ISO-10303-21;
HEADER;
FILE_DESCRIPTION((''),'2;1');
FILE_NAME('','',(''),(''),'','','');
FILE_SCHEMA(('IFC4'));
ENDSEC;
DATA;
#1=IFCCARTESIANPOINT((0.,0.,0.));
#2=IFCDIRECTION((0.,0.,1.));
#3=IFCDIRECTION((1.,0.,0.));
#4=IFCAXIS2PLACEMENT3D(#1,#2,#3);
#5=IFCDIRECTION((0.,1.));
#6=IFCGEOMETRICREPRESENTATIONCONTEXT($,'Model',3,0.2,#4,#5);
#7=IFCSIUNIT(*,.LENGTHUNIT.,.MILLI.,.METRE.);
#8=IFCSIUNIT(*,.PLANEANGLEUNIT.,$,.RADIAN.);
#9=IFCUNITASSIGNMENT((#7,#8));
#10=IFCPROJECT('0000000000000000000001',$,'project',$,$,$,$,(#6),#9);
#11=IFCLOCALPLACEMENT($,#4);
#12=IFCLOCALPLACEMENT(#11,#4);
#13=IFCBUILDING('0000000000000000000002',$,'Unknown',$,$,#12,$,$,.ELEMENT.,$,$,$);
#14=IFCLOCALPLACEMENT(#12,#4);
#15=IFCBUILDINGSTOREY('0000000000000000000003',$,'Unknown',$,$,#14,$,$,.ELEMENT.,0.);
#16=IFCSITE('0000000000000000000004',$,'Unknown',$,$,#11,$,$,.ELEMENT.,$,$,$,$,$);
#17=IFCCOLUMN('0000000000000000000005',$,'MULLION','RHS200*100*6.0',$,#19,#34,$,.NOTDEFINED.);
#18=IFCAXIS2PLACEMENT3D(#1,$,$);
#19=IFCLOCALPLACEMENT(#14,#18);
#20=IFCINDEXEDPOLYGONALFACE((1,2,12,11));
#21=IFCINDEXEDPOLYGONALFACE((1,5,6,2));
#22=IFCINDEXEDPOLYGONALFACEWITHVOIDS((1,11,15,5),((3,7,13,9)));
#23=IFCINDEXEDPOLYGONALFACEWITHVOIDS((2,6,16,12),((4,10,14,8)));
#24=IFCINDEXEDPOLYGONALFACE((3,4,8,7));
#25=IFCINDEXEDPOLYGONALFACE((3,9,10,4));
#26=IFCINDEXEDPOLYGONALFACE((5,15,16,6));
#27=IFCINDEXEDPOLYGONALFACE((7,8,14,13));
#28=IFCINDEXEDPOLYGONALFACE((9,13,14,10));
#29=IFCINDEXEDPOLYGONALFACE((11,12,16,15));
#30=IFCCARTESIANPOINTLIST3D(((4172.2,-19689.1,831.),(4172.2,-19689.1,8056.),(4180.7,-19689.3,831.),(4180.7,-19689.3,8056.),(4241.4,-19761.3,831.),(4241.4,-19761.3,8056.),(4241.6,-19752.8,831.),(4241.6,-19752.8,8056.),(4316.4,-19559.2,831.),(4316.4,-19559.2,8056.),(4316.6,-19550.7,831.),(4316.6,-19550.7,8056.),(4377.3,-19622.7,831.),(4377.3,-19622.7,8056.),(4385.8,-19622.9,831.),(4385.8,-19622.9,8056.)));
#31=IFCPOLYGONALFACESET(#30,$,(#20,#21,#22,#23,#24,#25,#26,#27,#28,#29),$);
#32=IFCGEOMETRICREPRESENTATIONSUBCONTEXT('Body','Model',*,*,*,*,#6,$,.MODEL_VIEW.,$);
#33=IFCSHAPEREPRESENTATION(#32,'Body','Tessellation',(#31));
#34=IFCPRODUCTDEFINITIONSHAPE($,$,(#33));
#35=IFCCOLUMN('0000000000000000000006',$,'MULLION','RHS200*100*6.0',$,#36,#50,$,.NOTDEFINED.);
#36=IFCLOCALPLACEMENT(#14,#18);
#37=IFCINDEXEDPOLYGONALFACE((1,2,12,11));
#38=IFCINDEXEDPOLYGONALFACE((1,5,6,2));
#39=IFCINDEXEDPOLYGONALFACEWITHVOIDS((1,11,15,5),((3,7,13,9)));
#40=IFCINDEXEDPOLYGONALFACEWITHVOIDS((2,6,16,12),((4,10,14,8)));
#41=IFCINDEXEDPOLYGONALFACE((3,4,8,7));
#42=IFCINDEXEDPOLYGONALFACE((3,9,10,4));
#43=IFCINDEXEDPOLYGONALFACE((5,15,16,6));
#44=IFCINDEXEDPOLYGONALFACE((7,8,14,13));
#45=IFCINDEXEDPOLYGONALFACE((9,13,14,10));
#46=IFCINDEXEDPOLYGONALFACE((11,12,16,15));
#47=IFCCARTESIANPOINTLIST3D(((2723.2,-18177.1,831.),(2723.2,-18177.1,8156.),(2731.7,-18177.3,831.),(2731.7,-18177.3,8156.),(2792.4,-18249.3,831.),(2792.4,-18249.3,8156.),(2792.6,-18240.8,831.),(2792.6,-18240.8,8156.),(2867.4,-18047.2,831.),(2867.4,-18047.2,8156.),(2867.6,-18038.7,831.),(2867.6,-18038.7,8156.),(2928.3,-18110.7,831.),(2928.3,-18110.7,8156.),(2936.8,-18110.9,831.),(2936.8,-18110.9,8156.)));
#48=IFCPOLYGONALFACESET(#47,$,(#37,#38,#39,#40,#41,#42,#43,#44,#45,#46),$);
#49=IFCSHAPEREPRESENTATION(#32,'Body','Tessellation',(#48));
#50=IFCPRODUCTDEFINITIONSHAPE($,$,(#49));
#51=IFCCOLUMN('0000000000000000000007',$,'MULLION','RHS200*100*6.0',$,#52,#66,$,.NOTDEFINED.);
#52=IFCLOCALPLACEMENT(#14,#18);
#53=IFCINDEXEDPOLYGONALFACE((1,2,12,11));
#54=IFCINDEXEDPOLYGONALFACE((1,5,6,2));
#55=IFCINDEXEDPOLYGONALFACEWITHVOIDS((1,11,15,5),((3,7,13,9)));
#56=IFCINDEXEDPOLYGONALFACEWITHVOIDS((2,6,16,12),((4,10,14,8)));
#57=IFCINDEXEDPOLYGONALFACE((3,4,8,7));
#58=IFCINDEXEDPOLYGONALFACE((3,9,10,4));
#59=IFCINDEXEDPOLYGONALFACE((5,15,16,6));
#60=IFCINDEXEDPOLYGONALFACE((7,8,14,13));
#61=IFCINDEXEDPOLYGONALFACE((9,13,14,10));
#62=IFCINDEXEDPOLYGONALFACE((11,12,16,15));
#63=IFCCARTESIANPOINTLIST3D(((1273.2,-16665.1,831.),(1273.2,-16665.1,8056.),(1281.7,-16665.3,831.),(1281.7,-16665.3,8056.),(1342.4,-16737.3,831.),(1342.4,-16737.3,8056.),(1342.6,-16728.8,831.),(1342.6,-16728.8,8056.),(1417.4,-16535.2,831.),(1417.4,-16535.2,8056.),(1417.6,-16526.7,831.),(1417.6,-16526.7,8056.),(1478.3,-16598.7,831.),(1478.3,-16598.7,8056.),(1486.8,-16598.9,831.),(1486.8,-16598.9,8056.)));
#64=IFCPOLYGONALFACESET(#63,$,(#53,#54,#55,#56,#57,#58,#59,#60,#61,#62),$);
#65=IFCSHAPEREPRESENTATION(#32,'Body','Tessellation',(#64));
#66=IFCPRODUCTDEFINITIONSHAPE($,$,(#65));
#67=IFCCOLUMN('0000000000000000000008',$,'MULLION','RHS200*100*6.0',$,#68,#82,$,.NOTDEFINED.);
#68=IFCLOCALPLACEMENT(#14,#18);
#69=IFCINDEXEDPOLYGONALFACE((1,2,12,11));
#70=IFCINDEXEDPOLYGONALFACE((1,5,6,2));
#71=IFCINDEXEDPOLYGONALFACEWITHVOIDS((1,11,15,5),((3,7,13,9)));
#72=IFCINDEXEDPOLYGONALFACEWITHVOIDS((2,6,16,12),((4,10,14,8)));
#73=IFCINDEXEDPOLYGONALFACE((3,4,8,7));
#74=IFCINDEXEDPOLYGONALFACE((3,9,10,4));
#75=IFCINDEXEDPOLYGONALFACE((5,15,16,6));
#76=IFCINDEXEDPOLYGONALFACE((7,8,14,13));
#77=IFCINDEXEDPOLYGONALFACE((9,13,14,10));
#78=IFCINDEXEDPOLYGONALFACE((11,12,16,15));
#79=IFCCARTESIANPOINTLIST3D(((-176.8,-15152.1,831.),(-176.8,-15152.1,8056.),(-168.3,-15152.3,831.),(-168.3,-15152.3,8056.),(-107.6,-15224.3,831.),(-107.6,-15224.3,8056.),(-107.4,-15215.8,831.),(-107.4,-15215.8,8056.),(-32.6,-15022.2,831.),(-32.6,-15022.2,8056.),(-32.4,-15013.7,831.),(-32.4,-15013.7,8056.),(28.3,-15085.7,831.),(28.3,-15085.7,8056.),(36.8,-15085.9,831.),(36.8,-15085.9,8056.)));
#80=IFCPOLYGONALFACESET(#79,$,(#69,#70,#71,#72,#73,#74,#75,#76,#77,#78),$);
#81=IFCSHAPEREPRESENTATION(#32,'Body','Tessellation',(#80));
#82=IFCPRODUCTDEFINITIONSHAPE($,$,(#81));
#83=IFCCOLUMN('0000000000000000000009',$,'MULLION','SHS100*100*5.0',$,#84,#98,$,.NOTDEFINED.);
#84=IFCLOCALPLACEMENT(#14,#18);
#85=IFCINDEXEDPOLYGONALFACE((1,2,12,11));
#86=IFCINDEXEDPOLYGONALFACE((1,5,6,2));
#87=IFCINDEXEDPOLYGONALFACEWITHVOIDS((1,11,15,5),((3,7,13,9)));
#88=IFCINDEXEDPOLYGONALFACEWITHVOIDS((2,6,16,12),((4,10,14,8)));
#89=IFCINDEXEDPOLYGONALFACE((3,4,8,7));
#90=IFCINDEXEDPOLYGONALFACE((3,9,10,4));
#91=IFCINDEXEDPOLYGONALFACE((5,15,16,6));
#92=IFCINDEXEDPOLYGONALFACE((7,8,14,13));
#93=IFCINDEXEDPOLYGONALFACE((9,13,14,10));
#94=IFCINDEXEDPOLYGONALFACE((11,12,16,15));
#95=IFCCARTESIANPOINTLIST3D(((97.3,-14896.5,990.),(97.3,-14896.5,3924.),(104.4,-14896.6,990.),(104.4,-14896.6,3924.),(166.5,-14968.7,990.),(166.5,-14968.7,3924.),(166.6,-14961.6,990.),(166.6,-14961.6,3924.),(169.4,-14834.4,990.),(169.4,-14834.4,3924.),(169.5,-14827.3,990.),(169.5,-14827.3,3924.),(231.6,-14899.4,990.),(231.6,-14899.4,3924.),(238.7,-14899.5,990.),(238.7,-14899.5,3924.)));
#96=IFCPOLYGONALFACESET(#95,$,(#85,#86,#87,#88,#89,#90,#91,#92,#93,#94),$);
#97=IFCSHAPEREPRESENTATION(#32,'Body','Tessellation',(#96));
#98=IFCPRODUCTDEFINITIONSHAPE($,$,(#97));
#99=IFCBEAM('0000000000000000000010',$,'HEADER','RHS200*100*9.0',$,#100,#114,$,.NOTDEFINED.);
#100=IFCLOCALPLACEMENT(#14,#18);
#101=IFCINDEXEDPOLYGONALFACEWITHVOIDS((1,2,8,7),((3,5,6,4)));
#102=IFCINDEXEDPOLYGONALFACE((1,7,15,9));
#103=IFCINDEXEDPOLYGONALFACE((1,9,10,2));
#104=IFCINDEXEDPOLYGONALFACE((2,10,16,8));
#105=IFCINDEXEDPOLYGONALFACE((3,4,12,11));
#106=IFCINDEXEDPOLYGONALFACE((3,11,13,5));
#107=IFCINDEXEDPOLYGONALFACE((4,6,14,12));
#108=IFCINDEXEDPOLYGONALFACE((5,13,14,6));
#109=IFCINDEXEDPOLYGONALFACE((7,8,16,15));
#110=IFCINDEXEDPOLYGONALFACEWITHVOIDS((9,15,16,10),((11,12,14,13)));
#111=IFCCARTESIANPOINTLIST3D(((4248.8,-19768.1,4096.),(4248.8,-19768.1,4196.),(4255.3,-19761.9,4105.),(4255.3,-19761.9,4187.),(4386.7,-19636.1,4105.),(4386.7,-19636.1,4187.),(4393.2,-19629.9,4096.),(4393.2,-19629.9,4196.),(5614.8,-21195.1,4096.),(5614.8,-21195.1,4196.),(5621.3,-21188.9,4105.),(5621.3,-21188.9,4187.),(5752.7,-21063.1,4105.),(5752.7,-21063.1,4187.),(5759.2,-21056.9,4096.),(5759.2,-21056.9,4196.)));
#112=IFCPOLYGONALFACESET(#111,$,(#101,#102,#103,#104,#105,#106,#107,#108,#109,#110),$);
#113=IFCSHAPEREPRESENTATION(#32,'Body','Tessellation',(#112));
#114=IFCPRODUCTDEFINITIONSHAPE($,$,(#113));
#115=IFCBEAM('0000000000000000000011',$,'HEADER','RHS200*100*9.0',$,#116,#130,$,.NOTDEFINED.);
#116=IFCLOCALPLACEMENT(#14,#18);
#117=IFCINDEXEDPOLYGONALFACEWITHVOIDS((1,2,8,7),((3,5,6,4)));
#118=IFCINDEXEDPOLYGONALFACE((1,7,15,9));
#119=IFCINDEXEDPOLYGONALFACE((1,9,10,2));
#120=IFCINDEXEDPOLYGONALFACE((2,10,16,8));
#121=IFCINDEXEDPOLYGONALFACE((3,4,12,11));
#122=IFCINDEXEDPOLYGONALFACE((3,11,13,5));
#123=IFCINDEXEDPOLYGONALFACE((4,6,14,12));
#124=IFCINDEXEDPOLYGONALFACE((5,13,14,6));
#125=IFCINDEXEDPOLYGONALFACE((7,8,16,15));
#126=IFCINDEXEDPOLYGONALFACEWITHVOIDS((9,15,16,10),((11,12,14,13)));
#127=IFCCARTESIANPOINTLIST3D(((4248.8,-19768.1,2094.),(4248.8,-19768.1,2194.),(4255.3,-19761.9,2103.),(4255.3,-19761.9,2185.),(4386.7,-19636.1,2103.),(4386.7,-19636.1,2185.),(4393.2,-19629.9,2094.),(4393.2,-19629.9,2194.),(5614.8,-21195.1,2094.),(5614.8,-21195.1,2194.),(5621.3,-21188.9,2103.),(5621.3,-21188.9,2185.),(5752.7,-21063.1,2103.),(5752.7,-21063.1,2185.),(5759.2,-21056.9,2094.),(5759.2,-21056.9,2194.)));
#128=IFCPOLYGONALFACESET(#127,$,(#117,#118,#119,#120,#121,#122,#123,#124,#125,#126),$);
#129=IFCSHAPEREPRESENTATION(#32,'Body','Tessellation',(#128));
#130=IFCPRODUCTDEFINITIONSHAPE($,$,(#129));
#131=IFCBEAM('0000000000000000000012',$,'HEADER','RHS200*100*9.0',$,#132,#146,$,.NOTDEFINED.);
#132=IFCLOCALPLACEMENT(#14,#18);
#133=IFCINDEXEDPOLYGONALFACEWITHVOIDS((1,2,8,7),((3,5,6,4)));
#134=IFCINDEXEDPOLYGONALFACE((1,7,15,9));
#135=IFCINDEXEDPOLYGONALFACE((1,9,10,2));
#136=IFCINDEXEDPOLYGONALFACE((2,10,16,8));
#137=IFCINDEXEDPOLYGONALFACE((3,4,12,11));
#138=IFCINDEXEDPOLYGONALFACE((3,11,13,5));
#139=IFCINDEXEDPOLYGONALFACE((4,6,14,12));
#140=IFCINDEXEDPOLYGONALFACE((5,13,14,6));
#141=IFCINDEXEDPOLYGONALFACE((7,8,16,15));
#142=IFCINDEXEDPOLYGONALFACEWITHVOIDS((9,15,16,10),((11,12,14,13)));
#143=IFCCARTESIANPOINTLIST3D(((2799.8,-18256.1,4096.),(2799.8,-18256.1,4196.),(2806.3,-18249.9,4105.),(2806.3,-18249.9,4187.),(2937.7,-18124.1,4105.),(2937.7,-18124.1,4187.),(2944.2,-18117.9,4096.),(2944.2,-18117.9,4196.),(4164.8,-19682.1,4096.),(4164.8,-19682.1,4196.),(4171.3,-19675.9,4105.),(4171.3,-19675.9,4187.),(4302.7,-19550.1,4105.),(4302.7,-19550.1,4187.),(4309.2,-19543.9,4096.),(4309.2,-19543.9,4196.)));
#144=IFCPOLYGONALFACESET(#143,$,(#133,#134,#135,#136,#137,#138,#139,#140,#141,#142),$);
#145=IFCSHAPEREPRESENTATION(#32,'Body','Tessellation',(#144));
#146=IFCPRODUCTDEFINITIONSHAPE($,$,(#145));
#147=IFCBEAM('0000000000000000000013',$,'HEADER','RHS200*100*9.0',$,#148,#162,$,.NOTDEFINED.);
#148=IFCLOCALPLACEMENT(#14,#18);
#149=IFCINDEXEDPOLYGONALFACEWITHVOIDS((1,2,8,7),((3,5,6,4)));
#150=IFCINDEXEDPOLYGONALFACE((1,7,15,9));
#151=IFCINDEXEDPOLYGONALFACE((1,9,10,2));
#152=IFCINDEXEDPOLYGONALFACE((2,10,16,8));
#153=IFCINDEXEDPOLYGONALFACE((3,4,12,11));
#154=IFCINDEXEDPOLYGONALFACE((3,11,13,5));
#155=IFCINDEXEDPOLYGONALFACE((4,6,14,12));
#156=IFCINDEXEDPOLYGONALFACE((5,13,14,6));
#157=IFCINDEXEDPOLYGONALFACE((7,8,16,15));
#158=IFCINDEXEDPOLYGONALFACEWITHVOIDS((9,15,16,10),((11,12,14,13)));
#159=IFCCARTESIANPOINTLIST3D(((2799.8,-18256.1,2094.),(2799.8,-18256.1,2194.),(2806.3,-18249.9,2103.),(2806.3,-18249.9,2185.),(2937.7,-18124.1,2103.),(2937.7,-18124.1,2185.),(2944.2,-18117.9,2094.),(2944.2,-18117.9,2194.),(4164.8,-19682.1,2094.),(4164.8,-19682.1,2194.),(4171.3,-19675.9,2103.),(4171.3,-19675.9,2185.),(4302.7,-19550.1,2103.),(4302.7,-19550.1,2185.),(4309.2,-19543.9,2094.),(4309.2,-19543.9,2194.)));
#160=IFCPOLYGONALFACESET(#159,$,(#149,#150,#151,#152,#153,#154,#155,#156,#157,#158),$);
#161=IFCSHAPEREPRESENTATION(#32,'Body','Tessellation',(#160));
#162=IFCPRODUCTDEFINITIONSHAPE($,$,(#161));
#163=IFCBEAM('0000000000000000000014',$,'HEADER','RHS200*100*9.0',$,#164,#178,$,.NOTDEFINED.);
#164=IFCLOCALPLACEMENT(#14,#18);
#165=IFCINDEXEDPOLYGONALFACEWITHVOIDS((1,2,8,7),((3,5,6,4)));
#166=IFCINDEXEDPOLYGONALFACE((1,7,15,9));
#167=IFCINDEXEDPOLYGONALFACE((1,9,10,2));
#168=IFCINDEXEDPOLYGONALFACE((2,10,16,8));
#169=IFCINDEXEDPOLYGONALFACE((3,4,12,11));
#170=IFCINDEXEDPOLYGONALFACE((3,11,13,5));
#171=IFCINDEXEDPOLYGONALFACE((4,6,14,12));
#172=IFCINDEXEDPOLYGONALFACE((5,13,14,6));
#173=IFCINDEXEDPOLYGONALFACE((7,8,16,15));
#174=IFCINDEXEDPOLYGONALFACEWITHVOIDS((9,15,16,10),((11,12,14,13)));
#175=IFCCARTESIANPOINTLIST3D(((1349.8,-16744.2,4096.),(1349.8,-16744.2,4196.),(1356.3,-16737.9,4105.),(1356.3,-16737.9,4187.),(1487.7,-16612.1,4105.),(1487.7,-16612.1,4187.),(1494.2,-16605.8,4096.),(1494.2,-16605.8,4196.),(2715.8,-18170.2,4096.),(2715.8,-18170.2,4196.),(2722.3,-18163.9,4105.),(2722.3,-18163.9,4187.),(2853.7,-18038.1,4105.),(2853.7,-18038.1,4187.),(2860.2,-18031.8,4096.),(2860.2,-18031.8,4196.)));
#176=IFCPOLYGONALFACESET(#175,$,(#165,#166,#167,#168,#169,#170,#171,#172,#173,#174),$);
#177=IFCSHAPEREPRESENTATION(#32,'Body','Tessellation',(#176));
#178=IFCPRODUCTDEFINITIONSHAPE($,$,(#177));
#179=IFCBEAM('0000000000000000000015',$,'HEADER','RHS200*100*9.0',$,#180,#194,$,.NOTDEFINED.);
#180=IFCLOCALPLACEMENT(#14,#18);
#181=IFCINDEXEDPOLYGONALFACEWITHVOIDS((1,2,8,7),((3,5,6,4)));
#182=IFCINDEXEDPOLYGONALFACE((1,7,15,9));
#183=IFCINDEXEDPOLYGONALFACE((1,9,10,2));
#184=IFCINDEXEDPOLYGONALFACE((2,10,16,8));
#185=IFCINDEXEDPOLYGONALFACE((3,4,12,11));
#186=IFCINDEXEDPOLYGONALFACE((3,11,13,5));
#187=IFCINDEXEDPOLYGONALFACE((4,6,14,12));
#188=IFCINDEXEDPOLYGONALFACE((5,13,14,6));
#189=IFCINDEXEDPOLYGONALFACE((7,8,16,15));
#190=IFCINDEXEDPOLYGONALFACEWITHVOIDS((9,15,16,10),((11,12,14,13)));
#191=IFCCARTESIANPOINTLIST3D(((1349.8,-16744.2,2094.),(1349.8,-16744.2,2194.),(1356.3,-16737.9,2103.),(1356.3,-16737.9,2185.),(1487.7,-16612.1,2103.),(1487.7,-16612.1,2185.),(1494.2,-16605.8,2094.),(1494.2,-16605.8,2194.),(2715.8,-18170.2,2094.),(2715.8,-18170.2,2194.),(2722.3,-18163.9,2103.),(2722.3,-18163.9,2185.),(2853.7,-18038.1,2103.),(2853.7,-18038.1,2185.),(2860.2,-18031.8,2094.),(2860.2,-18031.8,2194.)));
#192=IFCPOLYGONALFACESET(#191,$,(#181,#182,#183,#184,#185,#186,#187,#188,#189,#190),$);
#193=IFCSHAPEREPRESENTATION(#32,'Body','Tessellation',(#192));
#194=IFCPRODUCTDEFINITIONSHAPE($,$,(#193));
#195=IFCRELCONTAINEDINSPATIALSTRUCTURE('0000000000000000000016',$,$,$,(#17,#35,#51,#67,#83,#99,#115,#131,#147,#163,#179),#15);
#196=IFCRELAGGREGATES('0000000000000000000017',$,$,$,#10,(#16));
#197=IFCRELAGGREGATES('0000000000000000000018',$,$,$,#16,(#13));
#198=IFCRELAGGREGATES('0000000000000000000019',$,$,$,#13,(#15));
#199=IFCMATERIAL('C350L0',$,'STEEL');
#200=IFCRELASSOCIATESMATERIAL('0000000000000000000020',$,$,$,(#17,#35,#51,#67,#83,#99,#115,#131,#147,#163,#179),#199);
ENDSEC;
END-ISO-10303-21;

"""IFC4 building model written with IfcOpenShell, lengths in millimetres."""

from ifc_helpers import new_model, si_unit, direction, frame, origin_with_axes, place, context, subcontext, project, spatial, line, indexed_curve, outline, extrude, material, element, save


model = new_model("IFC4")

# Units and contexts
model_context = context("Model", 3, precision=0.2, world=origin_with_axes(), true_north=direction((0.0, 1.0)))
body_context = subcontext(model_context, "Body", "Model", "MODEL_VIEW")
ifc_project = project(units=[si_unit("LENGTHUNIT", "METRE", prefix="MILLI"), si_unit("PLANEANGLEUNIT", "RADIAN")], contexts=[model_context])

# Site, building, storey
site_placement = place(None, origin_with_axes())
site = spatial("IfcSite", under=ifc_project, at=site_placement, Name="Unknown", CompositionType="ELEMENT")
building_placement = place(site_placement, origin_with_axes())
building = spatial("IfcBuilding", under=site, at=building_placement, Name="Unknown", CompositionType="ELEMENT")
storey_placement = place(building_placement, origin_with_axes())
storey = spatial("IfcBuildingStorey", under=building, at=storey_placement, Name="Unknown", CompositionType="ELEMENT", Elevation=0.0)

# Columns
ifc_material_1 = material(Name="C350L0", Category="STEEL")
column_1_placement = place(storey_placement, frame((4279.0, -19656.0, 831.0), z_axis=(0.691765, -0.722123, 0.0), x_axis=(0.0, 0.0, 1.0)))
element("IfcColumn", 1, at=column_1_placement, inside=storey, material=ifc_material_1, Name="MULLION", Description="RHS200*100*6.0", PredefinedType="NOTDEFINED", context=body_context, shape_type="SolidModel", body=[
    extrude(outline(indexed_curve([(-50.0, -100.0), (50.0, -100.0), (50.0, 100.0), (-50.0, 100.0)], segments=[line(1, 2, 3, 4, 1)]), holes=[indexed_curve([(-44.0, -94.0), (-44.0, 94.0), (44.0, 94.0), (44.0, -94.0)], segments=[line(1, 2, 3, 4, 1)])]), frame((0.0, 0.0, 0.0), z_axis=(-1.0, 0.0, 0.0), x_axis=(0.0, 0.0, 1.0)), (0.0, 0.0, -1.0), 7225.0),
])
column_2_placement = place(storey_placement, frame((2830.0, -18144.0, 831.0), z_axis=(0.691765, -0.722123, 0.0), x_axis=(0.0, 0.0, 1.0)))
element("IfcColumn", 2, at=column_2_placement, inside=storey, material=ifc_material_1, Name="MULLION", Description="RHS200*100*6.0", PredefinedType="NOTDEFINED", context=body_context, shape_type="SolidModel", body=[
    extrude(outline(indexed_curve([(-50.0, -100.0), (50.0, -100.0), (50.0, 100.0), (-50.0, 100.0)], segments=[line(1, 2, 3, 4, 1)]), holes=[indexed_curve([(-44.0, -94.0), (-44.0, 94.0), (44.0, 94.0), (44.0, -94.0)], segments=[line(1, 2, 3, 4, 1)])]), frame((0.0, 0.0, 0.0), z_axis=(-1.0, 0.0, 0.0), x_axis=(0.0, 0.0, 1.0)), (0.0, 0.0, -1.0), 7325.0),
])
for number, where, z_axis, x_axis, name in (
    (3, (1380.0, -16632.0, 831.0), (0.691891, -0.722002, 0.0), (0.0, 0.0, 1.0), "MULLION"),
    (4, (-70.0, -15119.0, 831.0), (0.691891, -0.722002, 0.0), (0.0, 0.0, 1.0), "MULLION"),
):
    element("IfcColumn", number, at=place(storey_placement, frame(where, z_axis=z_axis, x_axis=x_axis)), inside=storey, material=ifc_material_1, Name=name, Description="RHS200*100*6.0", PredefinedType="NOTDEFINED", context=body_context, shape_type="SolidModel", body=[
        extrude(outline(indexed_curve([(-50.0, -100.0), (50.0, -100.0), (50.0, 100.0), (-50.0, 100.0)], segments=[line(1, 2, 3, 4, 1)]), holes=[indexed_curve([(-44.0, -94.0), (-44.0, 94.0), (44.0, 94.0), (44.0, -94.0)], segments=[line(1, 2, 3, 4, 1)])]), frame((0.0, 0.0, 0.0), z_axis=(-1.0, 0.0, 0.0), x_axis=(0.0, 0.0, 1.0)), (0.0, 0.0, -1.0), 7225.0),
    ])
column_3_placement = place(storey_placement, frame((168.0, -14898.0, 990.0), z_axis=(0.722364, 0.691513, 0.0), x_axis=(0.0, 0.0, 1.0)))
element("IfcColumn", 5, at=column_3_placement, inside=storey, material=ifc_material_1, Name="MULLION", Description="SHS100*100*5.0", PredefinedType="NOTDEFINED", context=body_context, shape_type="SolidModel", body=[
    extrude(outline(indexed_curve([(-50.0, -50.0), (50.0, -50.0), (50.0, 50.0), (-50.0, 50.0)], segments=[line(1, 2, 3, 4, 1)]), holes=[indexed_curve([(-45.0, -45.0), (-45.0, 45.0), (45.0, 45.0), (45.0, -45.0)], segments=[line(1, 2, 3, 4, 1)])]), frame((0.0, 0.0, 0.0), z_axis=(-1.0, 0.0, 0.0), x_axis=(0.0, 0.0, 1.0)), (0.0, 0.0, -1.0), 2934.0),
])

# Beams
for number, where, z_axis, x_axis, name in (
    (6, (4321.0, -19699.0, 4146.0), (0.0, 0.0, 1.0), (0.691498, -0.722378, 0.0), "HEADER"),
    (7, (4321.0, -19699.0, 2144.0), (0.0, 0.0, 1.0), (0.691498, -0.722378, 0.0), "HEADER"),
):
    element("IfcBeam", number, at=place(storey_placement, frame(where, z_axis=z_axis, x_axis=x_axis)), inside=storey, material=ifc_material_1, Name=name, Description="RHS200*100*9.0", PredefinedType="NOTDEFINED", context=body_context, shape_type="SolidModel", body=[
        extrude(outline(indexed_curve([(-50.0, -100.0), (50.0, -100.0), (50.0, 100.0), (-50.0, 100.0)], segments=[line(1, 2, 3, 4, 1)]), holes=[indexed_curve([(-41.0, -91.0), (-41.0, 91.0), (41.0, 91.0), (41.0, -91.0)], segments=[line(1, 2, 3, 4, 1)])]), frame((0.0, 0.0, 0.0), z_axis=(-1.0, 0.0, 0.0), x_axis=(0.0, 0.0, 1.0)), (0.0, 0.0, -1.0), 1975.4),
    ])
for number, where, z_axis, x_axis, name in (
    (8, (2872.0, -18187.0, 4146.0), (0.0, 0.0, 1.0), (0.691487, -0.722389, 0.0), "HEADER"),
    (9, (2872.0, -18187.0, 2144.0), (0.0, 0.0, 1.0), (0.691487, -0.722389, 0.0), "HEADER"),
):
    element("IfcBeam", number, at=place(storey_placement, frame(where, z_axis=z_axis, x_axis=x_axis)), inside=storey, material=ifc_material_1, Name=name, Description="RHS200*100*9.0", PredefinedType="NOTDEFINED", context=body_context, shape_type="SolidModel", body=[
        extrude(outline(indexed_curve([(-50.0, -100.0), (50.0, -100.0), (50.0, 100.0), (-50.0, 100.0)], segments=[line(1, 2, 3, 4, 1)]), holes=[indexed_curve([(-41.0, -91.0), (-41.0, 91.0), (41.0, 91.0), (41.0, -91.0)], segments=[line(1, 2, 3, 4, 1)])]), frame((0.0, 0.0, 0.0), z_axis=(-1.0, 0.0, 0.0), x_axis=(0.0, 0.0, 1.0)), (0.0, 0.0, -1.0), 1974.0),
    ])
for number, where, z_axis, x_axis, name in (
    (10, (1422.0, -16675.0, 4146.0), (0.0, 0.0, 1.0), (0.691751, -0.722136, 0.0), "HEADER"),
    (11, (1422.0, -16675.0, 2144.0), (0.0, 0.0, 1.0), (0.691751, -0.722136, 0.0), "HEADER"),
):
    element("IfcBeam", number, at=place(storey_placement, frame(where, z_axis=z_axis, x_axis=x_axis)), inside=storey, material=ifc_material_1, Name=name, Description="RHS200*100*9.0", PredefinedType="NOTDEFINED", context=body_context, shape_type="SolidModel", body=[
        extrude(outline(indexed_curve([(-50.0, -100.0), (50.0, -100.0), (50.0, 100.0), (-50.0, 100.0)], segments=[line(1, 2, 3, 4, 1)]), holes=[indexed_curve([(-41.0, -91.0), (-41.0, 91.0), (41.0, 91.0), (41.0, -91.0)], segments=[line(1, 2, 3, 4, 1)])]), frame((0.0, 0.0, 0.0), z_axis=(-1.0, 0.0, 0.0), x_axis=(0.0, 0.0, 1.0)), (0.0, 0.0, -1.0), 1974.7),
    ])

save(model, "model.ifc")
